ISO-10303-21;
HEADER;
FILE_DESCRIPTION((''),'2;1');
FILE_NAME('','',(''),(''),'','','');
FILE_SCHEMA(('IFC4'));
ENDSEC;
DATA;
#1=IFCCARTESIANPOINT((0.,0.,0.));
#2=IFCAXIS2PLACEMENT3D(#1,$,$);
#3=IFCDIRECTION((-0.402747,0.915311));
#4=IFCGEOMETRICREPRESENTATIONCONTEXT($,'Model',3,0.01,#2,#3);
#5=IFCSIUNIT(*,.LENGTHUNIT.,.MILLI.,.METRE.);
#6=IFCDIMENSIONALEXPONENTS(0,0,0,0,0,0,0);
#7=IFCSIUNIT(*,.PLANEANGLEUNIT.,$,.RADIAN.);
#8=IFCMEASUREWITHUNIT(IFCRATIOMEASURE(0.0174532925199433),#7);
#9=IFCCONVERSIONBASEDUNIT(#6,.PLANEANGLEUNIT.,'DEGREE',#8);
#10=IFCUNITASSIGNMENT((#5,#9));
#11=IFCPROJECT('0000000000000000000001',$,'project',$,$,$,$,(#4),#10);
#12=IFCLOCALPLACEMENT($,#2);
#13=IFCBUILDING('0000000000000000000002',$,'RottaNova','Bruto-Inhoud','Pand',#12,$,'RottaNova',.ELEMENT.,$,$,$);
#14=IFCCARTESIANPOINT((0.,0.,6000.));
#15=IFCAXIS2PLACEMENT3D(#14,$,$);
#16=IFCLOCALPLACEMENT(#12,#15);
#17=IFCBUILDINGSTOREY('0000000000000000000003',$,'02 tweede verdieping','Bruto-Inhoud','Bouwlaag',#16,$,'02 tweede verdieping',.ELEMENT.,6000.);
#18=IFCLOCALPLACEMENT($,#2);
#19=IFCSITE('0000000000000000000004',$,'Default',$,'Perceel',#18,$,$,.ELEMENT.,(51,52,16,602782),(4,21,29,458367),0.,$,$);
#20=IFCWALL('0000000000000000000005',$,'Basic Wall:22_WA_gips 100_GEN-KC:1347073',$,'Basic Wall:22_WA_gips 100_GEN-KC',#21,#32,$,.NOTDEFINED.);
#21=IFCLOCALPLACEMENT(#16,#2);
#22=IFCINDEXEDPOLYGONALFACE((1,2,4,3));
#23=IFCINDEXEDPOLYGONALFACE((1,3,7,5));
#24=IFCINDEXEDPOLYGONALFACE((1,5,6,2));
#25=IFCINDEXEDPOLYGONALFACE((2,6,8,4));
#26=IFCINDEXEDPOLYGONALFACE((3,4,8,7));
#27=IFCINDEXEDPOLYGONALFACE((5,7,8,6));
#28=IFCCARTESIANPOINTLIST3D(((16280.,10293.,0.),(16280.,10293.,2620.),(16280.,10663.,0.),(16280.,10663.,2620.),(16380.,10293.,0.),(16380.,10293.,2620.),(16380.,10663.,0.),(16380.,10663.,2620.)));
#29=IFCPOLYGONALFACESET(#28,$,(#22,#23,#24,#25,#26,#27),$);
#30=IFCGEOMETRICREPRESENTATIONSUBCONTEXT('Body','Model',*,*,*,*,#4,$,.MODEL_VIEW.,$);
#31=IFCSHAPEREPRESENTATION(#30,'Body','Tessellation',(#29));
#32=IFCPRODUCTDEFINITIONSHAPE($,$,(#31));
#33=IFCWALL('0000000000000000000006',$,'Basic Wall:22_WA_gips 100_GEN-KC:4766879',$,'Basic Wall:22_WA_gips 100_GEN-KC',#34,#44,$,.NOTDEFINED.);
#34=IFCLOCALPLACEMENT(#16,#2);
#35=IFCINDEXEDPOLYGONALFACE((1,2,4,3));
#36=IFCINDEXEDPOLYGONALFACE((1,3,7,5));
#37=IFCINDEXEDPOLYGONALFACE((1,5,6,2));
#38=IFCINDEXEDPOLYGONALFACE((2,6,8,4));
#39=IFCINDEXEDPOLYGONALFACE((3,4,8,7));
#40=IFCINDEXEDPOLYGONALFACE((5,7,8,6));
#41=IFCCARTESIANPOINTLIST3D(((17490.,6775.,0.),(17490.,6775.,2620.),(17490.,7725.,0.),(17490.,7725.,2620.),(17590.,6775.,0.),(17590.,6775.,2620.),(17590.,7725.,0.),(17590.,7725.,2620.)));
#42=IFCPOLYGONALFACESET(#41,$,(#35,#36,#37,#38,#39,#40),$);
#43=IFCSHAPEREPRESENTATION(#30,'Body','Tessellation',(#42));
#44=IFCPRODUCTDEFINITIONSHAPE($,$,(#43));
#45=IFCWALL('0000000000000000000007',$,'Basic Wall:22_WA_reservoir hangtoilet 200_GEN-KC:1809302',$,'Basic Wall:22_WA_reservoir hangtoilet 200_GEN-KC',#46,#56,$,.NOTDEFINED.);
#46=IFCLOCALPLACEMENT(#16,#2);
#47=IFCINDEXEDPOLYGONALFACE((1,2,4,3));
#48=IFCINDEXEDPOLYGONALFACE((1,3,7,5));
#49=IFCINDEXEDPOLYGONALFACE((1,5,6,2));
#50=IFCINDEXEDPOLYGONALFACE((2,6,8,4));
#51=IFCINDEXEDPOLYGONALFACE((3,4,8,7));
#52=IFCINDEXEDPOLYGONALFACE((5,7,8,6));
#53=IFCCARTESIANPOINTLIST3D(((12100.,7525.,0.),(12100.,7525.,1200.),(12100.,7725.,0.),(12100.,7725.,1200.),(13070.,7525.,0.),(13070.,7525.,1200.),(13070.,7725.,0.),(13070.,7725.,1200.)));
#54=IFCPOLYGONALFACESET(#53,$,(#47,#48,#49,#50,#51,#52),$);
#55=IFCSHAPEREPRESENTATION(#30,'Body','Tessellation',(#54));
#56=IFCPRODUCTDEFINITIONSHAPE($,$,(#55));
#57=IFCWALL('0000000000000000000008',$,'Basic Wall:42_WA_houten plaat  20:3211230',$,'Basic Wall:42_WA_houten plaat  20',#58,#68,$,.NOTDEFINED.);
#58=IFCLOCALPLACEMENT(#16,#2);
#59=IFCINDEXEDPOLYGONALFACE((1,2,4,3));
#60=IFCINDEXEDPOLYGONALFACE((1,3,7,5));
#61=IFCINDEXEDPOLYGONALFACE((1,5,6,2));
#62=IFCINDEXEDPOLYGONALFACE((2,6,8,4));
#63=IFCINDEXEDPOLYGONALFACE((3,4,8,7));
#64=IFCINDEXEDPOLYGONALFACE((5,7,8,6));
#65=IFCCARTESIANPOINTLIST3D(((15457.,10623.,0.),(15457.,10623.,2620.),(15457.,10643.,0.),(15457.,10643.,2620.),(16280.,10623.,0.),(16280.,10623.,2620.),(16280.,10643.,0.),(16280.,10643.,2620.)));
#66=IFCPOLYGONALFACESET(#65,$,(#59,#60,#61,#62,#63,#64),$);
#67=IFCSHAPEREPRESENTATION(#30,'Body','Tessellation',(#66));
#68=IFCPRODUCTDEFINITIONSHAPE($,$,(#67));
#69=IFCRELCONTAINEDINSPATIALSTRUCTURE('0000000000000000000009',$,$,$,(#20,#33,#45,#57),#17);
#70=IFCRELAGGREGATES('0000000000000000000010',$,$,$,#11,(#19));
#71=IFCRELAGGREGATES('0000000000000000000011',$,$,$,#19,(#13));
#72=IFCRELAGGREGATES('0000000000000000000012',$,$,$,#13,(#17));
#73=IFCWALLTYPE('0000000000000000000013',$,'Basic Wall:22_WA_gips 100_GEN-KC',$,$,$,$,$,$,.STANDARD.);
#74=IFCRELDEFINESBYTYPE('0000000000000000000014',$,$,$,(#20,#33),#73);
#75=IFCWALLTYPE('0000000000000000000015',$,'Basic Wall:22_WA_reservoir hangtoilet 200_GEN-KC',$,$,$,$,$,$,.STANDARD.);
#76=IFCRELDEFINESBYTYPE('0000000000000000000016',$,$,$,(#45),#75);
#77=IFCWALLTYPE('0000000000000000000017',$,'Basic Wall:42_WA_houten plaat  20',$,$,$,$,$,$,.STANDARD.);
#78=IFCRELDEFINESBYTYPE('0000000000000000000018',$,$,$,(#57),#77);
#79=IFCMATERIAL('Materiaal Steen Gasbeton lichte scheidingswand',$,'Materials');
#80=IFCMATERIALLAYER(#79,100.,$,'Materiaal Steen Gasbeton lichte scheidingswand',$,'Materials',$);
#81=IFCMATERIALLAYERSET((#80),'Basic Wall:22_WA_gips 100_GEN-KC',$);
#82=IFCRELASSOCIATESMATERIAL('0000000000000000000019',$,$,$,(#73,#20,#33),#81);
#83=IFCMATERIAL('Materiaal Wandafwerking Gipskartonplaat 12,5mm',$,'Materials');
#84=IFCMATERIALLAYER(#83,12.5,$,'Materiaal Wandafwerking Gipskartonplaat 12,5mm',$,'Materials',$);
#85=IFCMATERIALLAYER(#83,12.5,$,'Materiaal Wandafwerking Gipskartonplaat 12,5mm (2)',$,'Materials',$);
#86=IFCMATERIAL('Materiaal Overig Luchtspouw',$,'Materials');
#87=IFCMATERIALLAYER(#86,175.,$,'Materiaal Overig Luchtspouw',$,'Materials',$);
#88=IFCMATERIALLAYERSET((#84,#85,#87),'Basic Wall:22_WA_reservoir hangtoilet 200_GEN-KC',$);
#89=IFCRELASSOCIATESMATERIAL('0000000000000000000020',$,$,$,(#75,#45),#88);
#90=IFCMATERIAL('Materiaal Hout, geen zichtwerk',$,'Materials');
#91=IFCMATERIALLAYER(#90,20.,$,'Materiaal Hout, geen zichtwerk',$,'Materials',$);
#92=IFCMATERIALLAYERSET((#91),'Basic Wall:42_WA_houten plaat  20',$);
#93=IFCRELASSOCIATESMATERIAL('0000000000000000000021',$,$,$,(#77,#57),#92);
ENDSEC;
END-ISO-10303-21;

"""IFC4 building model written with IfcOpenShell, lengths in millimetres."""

from ifc_helpers import new_model, entity, si_unit, converted_unit, direction, frame, frame_2d, origin, place, context, subcontext, project, spatial, rectangle, extrude, material, layer, layer_set, type_object, element, save


model = new_model("IFC4")

# Units and contexts
model_context = context("Model", 3, precision=0.01, world=origin(), true_north=direction((-0.402747, 0.915311)))
body_context = subcontext(model_context, "Body", "Model", "MODEL_VIEW")
ifc_project = project(units=[si_unit("LENGTHUNIT", "METRE", prefix="MILLI"), converted_unit("PLANEANGLEUNIT", "DEGREE", entity("IfcRatioMeasure", 0.0174532925199433), si_unit("PLANEANGLEUNIT", "RADIAN"), dimensions=[0, 0, 0, 0, 0, 0, 0])], contexts=[model_context])

# Site, building, storey
site_placement = place(None, origin())
site = spatial("IfcSite", under=ifc_project, at=site_placement, Name="Default", ObjectType="Perceel", CompositionType="ELEMENT", RefLatitude=(51, 52, 16, 602782), RefLongitude=(4, 21, 29, 458367), RefElevation=0.0)
building_placement = place(None, origin())
building = spatial("IfcBuilding", under=site, at=building_placement, Name="RottaNova", Description="Bruto-Inhoud", ObjectType="Pand", LongName="RottaNova", CompositionType="ELEMENT")
storey_placement = place(building_placement, frame((0.0, 0.0, 6000.0)))
storey = spatial("IfcBuildingStorey", under=building, at=storey_placement, Name="02 tweede verdieping", Description="Bruto-Inhoud", ObjectType="Bouwlaag", LongName="02 tweede verdieping", CompositionType="ELEMENT", Elevation=6000.0)

# Shared definitions
ifc_material_1 = material(Name="Materiaal Steen Gasbeton lichte scheidingswand", Category="Materials")
ifc_layer_1 = layer(ifc_material_1, 100.0, Name="Materiaal Steen Gasbeton lichte scheidingswand", Category="Materials")
ifc_layer_set_1 = layer_set([ifc_layer_1], Name="Basic Wall:22_WA_gips 100_GEN-KC")
wall_type_1 = type_object("IfcWallType", Name="Basic Wall:22_WA_gips 100_GEN-KC", PredefinedType="STANDARD", material=ifc_layer_set_1)

# Walls
wall_1_placement = place(storey_placement, frame((16330.0, 10663.0, 0.0), z_axis=(0.0, 0.0, 1.0), x_axis=(0.0, -1.0, 0.0)))
element("IfcWall", 1, at=wall_1_placement, inside=storey, type_object=wall_type_1, material=ifc_layer_set_1, Name="Basic Wall:22_WA_gips 100_GEN-KC:1347073", ObjectType="Basic Wall:22_WA_gips 100_GEN-KC", PredefinedType="NOTDEFINED", context=body_context, shape_type="SweptSolid", body=[
    extrude(rectangle(XDim=370.0, YDim=100.0, at=frame_2d((185.0, 0.0), x_axis=(-1.0, 0.0))), origin(), (0.0, 0.0, 1.0), 2620.0),
])
wall_2_placement = place(storey_placement, frame((17540.0, 7725.0, 0.0), z_axis=(0.0, 0.0, 1.0), x_axis=(0.0, -1.0, 0.0)))
element("IfcWall", 2, at=wall_2_placement, inside=storey, type_object=wall_type_1, material=ifc_layer_set_1, Name="Basic Wall:22_WA_gips 100_GEN-KC:4766879", ObjectType="Basic Wall:22_WA_gips 100_GEN-KC", PredefinedType="NOTDEFINED", context=body_context, shape_type="SweptSolid", body=[
    extrude(rectangle(XDim=950.0, YDim=100.0, at=frame_2d((475.0, 0.0), x_axis=(-1.0, 0.0))), origin(), (0.0, 0.0, 1.0), 2620.0),
])
ifc_material_2 = material(Name="Materiaal Wandafwerking Gipskartonplaat 12,5mm", Category="Materials")
ifc_layer_2 = layer(ifc_material_2, 12.5, Name="Materiaal Wandafwerking Gipskartonplaat 12,5mm", Category="Materials")
ifc_layer_3 = layer(ifc_material_2, 12.5, Name="Materiaal Wandafwerking Gipskartonplaat 12,5mm (2)", Category="Materials")
ifc_material_3 = material(Name="Materiaal Overig Luchtspouw", Category="Materials")
ifc_layer_4 = layer(ifc_material_3, 175.0, Name="Materiaal Overig Luchtspouw", Category="Materials")
ifc_layer_set_2 = layer_set([ifc_layer_2, ifc_layer_3, ifc_layer_4], Name="Basic Wall:22_WA_reservoir hangtoilet 200_GEN-KC")
wall_type_2 = type_object("IfcWallType", Name="Basic Wall:22_WA_reservoir hangtoilet 200_GEN-KC", PredefinedType="STANDARD", material=ifc_layer_set_2)
wall_3_placement = place(storey_placement, frame((13070.0, 7625.0, 0.0), z_axis=(0.0, 0.0, 1.0), x_axis=(-1.0, 0.0, 0.0)))
element("IfcWall", 3, at=wall_3_placement, inside=storey, type_object=wall_type_2, material=ifc_layer_set_2, Name="Basic Wall:22_WA_reservoir hangtoilet 200_GEN-KC:1809302", ObjectType="Basic Wall:22_WA_reservoir hangtoilet 200_GEN-KC", PredefinedType="NOTDEFINED", context=body_context, shape_type="SweptSolid", body=[
    extrude(rectangle(XDim=970.0, YDim=200.0, at=frame_2d((485.0, 0.0), x_axis=(-1.0, 0.0))), origin(), (0.0, 0.0, 1.0), 1200.0),
])
ifc_material_4 = material(Name="Materiaal Hout, geen zichtwerk", Category="Materials")
ifc_layer_5 = layer(ifc_material_4, 20.0, Name="Materiaal Hout, geen zichtwerk", Category="Materials")
ifc_layer_set_3 = layer_set([ifc_layer_5], Name="Basic Wall:42_WA_houten plaat  20")
wall_type_3 = type_object("IfcWallType", Name="Basic Wall:42_WA_houten plaat  20", PredefinedType="STANDARD", material=ifc_layer_set_3)
wall_4_placement = place(storey_placement, frame((16280.0, 10633.0, 0.0), z_axis=(0.0, 0.0, 1.0), x_axis=(-1.0, 0.0, 0.0)))
element("IfcWall", 4, at=wall_4_placement, inside=storey, type_object=wall_type_3, material=ifc_layer_set_3, Name="Basic Wall:42_WA_houten plaat  20:3211230", ObjectType="Basic Wall:42_WA_houten plaat  20", PredefinedType="NOTDEFINED", context=body_context, shape_type="SweptSolid", body=[
    extrude(rectangle(XDim=823.0, YDim=20.0, at=frame_2d((411.5, 0.0), x_axis=(-1.0, 0.0))), origin(), (0.0, 0.0, 1.0), 2620.0),
])

save(model, "model.ifc")
